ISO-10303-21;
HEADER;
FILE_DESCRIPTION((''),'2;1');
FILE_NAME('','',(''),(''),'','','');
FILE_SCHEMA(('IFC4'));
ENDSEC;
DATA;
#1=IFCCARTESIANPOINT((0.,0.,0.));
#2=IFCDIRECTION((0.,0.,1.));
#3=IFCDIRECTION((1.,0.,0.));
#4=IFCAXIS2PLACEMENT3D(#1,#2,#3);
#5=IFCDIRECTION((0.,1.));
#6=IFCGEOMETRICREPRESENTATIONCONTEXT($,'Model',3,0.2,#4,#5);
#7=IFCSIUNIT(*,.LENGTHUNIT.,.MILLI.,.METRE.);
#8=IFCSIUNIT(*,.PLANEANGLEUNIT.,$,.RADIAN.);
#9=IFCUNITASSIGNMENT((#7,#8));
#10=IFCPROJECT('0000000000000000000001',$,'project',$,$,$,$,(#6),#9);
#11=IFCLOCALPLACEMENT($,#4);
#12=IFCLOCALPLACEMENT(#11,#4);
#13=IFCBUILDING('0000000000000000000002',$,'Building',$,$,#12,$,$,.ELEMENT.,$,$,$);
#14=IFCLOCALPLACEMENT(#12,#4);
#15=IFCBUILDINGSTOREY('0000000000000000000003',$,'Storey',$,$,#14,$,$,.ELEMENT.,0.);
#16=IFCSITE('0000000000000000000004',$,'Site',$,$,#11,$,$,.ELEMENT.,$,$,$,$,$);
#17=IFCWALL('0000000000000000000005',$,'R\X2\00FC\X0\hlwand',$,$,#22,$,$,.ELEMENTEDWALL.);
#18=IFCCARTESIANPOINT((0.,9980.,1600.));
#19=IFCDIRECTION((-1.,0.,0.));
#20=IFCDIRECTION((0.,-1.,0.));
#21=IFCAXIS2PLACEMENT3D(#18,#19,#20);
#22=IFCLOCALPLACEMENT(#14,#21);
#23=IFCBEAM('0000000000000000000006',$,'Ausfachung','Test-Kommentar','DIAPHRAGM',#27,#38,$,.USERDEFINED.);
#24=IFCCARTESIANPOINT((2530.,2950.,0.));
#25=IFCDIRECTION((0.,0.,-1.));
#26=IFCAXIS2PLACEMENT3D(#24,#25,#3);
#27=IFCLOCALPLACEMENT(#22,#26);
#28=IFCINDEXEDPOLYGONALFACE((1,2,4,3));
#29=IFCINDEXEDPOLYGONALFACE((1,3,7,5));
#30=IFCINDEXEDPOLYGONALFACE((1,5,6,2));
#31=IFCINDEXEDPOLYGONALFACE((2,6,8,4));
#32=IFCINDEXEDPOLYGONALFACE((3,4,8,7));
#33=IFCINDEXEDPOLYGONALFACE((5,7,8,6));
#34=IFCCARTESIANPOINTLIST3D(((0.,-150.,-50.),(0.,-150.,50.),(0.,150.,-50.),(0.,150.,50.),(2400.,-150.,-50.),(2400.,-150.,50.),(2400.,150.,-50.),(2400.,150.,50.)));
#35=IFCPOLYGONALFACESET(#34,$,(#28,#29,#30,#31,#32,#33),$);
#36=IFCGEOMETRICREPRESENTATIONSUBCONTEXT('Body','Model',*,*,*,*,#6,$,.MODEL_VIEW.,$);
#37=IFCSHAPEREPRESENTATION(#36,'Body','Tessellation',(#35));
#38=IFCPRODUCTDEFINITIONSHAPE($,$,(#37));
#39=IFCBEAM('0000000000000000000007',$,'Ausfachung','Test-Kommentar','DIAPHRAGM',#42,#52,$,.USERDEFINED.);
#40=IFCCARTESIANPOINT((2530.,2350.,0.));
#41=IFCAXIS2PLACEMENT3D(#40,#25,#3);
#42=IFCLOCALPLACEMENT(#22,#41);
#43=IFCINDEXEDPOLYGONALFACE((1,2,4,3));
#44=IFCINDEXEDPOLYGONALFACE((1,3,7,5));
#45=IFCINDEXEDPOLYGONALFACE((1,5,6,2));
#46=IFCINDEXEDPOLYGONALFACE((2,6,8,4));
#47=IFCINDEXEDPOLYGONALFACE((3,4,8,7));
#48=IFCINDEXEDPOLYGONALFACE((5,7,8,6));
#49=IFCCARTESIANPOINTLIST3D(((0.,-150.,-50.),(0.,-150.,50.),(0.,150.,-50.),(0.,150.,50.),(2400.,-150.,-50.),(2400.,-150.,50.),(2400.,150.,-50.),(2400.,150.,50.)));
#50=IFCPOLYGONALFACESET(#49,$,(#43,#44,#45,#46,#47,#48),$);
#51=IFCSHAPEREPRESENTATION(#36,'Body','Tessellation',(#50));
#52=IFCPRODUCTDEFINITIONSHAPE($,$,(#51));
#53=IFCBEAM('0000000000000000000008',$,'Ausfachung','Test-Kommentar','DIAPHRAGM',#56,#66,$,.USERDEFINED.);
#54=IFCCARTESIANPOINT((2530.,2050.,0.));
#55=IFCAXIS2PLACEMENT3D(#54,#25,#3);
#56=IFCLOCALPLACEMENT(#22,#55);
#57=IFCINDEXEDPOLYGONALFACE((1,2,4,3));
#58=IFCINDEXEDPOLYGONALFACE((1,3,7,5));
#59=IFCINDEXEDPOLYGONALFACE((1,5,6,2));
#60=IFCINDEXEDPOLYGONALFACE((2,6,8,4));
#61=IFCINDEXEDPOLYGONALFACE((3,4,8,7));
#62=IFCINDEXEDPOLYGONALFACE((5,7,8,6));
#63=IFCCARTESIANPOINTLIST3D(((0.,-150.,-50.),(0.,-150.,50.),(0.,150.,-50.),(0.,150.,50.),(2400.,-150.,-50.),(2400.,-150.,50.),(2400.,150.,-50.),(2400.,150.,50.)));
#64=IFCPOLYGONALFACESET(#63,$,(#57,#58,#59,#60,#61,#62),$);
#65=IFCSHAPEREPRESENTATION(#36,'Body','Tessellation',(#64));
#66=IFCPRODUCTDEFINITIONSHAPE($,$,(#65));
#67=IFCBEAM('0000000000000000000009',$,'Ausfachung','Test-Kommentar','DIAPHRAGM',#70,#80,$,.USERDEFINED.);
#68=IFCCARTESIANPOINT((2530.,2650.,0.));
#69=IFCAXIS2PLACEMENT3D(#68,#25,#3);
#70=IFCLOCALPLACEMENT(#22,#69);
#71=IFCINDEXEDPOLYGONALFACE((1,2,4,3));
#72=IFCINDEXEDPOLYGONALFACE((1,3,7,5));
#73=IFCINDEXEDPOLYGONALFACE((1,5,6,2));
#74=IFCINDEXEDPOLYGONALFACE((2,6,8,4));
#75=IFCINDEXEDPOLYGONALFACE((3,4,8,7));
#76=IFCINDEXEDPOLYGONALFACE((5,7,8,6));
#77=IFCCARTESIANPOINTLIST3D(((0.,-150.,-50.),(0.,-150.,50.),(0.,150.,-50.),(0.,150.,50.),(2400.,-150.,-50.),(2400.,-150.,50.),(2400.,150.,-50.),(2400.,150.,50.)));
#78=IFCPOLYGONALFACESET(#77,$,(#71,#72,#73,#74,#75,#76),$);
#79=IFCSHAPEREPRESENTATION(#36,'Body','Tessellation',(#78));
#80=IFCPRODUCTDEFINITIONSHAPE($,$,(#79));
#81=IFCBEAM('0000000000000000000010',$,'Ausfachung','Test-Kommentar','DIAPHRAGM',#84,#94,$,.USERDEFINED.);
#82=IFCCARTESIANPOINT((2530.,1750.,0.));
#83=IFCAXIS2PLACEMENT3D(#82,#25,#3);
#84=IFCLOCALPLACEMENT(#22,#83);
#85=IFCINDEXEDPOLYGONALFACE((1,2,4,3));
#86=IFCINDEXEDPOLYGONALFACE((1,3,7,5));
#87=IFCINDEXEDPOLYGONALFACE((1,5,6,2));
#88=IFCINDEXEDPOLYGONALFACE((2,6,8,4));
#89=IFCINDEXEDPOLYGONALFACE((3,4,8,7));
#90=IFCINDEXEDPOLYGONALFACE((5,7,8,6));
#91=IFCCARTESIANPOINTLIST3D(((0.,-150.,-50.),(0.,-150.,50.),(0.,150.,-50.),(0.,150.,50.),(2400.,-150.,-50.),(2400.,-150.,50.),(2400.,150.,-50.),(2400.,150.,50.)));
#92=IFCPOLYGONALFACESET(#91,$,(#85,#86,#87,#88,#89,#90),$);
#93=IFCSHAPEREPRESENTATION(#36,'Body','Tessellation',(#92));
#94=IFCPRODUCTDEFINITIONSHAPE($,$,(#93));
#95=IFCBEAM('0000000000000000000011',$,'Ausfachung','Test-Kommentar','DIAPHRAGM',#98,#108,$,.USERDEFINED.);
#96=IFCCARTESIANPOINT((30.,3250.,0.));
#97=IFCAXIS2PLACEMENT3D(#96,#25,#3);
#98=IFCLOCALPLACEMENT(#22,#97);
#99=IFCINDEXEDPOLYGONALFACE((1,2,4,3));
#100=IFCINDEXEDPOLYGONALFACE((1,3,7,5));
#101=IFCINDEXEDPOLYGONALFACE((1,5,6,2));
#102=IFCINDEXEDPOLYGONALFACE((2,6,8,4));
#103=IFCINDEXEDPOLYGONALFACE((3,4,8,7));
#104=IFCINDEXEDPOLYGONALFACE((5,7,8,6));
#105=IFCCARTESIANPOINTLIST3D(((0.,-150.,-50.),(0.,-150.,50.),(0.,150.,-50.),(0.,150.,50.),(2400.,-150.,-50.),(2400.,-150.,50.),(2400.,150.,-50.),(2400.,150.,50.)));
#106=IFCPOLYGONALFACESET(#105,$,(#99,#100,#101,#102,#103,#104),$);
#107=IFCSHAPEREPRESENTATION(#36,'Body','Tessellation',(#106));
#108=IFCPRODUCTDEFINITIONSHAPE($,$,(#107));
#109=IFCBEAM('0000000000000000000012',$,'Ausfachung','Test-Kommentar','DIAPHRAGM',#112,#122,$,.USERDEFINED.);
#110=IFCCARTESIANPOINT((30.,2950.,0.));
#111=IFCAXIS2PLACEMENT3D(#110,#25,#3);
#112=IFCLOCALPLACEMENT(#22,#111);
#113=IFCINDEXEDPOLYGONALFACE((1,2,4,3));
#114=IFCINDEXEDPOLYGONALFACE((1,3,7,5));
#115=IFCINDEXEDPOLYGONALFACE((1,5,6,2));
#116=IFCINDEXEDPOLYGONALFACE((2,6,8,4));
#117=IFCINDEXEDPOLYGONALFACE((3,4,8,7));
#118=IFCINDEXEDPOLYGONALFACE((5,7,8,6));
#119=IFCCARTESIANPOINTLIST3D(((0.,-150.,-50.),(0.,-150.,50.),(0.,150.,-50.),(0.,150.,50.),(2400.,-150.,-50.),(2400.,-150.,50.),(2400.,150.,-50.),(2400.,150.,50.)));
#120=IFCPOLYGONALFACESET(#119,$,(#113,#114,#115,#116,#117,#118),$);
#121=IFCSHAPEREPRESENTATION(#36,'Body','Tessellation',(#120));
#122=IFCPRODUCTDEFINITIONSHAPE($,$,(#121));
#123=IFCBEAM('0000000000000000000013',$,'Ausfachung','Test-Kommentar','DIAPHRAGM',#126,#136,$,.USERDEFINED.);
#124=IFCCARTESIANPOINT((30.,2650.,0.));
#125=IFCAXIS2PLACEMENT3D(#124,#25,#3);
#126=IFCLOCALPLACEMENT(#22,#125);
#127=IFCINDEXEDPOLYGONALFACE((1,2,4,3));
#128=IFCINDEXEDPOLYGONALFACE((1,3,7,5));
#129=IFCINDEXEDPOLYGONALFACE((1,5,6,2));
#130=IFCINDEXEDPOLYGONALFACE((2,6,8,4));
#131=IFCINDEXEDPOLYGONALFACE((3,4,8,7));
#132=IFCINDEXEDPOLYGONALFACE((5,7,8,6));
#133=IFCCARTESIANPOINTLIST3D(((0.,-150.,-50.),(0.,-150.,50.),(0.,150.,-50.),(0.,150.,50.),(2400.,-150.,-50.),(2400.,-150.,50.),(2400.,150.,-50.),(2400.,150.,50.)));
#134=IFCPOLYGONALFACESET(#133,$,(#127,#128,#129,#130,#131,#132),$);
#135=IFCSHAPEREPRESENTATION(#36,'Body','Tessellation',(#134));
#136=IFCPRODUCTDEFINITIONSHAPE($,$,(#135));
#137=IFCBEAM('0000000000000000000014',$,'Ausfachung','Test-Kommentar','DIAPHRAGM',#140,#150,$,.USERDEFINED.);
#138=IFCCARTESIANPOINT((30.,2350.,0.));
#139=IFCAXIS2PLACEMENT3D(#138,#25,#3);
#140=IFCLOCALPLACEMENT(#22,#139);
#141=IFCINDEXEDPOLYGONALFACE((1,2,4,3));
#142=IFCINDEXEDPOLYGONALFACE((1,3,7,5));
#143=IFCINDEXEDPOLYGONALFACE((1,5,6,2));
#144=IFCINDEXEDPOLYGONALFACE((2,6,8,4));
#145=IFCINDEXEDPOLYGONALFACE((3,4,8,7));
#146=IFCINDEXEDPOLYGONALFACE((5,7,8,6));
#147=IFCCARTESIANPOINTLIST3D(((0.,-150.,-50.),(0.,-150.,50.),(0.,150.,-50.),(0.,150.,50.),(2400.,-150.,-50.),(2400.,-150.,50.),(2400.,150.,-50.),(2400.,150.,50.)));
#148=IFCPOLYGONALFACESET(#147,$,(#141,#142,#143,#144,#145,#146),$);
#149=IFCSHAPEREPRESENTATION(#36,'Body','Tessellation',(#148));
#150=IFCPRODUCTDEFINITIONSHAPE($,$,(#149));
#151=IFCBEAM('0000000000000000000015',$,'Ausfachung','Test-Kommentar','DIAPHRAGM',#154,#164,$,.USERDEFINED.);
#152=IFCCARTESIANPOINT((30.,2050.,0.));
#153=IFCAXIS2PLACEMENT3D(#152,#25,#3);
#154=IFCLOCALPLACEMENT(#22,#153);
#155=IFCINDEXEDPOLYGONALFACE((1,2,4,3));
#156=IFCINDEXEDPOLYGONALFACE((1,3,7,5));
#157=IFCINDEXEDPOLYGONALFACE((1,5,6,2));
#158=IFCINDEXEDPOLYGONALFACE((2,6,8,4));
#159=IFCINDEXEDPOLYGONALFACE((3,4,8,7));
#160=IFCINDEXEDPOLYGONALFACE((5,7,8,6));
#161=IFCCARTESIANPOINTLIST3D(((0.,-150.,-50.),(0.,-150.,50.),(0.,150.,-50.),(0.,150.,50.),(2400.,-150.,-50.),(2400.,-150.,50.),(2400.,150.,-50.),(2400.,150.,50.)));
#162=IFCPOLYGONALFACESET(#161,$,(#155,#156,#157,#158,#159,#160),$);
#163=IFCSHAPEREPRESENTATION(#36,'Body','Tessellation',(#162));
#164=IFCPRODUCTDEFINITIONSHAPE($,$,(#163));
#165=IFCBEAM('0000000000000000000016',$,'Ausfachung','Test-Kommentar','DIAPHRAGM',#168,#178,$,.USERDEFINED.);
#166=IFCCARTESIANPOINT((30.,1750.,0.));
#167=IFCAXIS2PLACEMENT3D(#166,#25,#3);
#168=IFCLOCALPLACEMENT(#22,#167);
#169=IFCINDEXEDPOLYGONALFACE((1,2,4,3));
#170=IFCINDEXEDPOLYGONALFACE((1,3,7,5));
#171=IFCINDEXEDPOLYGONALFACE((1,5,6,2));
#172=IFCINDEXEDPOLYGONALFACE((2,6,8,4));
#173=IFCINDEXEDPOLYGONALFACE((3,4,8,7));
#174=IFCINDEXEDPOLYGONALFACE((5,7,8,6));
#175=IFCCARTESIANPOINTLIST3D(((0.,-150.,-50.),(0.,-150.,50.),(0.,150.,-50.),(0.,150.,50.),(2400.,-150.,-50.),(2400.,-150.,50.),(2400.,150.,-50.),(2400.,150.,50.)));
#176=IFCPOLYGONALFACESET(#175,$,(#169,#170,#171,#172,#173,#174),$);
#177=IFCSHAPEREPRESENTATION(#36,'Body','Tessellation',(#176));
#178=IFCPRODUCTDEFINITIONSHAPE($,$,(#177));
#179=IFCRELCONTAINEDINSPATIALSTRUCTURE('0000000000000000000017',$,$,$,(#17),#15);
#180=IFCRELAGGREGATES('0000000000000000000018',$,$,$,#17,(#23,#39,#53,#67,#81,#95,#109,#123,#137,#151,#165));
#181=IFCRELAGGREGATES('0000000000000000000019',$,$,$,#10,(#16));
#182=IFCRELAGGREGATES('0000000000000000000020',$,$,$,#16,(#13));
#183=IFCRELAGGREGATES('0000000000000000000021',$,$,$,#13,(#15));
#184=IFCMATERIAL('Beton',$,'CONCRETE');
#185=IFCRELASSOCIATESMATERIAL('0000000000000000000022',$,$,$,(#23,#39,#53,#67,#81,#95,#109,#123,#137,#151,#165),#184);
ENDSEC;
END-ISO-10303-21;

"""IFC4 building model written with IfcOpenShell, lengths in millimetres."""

from ifc_helpers import new_model, si_unit, direction, frame, origin_with_axes, place, context, subcontext, project, spatial, line, indexed_curve, outline, extrude, material, element, aggregate, save


model = new_model("IFC4")

# Units and contexts
model_context = context("Model", 3, precision=0.2, world=origin_with_axes(), true_north=direction((0.0, 1.0)))
body_context = subcontext(model_context, "Body", "Model", "MODEL_VIEW")
ifc_project = project(units=[si_unit("LENGTHUNIT", "METRE", prefix="MILLI"), si_unit("PLANEANGLEUNIT", "RADIAN")], contexts=[model_context])

# Site, building, storey
site_placement = place(None, origin_with_axes())
site = spatial("IfcSite", under=ifc_project, at=site_placement, Name="Site", CompositionType="ELEMENT")
building_placement = place(site_placement, origin_with_axes())
building = spatial("IfcBuilding", under=site, at=building_placement, Name="Building", CompositionType="ELEMENT")
storey_placement = place(building_placement, origin_with_axes())
storey = spatial("IfcBuildingStorey", under=building, at=storey_placement, Name="Storey", CompositionType="ELEMENT", Elevation=0.0)

# Wall, beams
wall_placement = place(storey_placement, frame((0.0, 9980.0, 1600.0), z_axis=(-1.0, 0.0, 0.0), x_axis=(0.0, -1.0, 0.0)))
wall = element("IfcWall", 1, at=wall_placement, inside=storey, Name="Rühlwand", PredefinedType="ELEMENTEDWALL")
ifc_material_1 = material(Name="Beton", Category="CONCRETE")
beam_1_placement = place(wall_placement, frame((2530.0, 2950.0, 0.0), z_axis=(0.0, 0.0, -1.0), x_axis=(1.0, 0.0, 0.0)))
beam_1 = element("IfcBeam", 2, at=beam_1_placement, material=ifc_material_1, Name="Ausfachung", Description="Test-Kommentar", ObjectType="DIAPHRAGM", PredefinedType="USERDEFINED", context=body_context, shape_type="SolidModel", body=[
    extrude(outline(indexed_curve([(-50.0, -150.0), (50.0, -150.0), (50.0, 150.0), (-50.0, 150.0)], segments=[line(1, 2, 3, 4, 1)])), frame((0.0, 0.0, 0.0), z_axis=(-1.0, 0.0, 0.0), x_axis=(0.0, 0.0, 1.0)), (0.0, 0.0, -1.0), 2400.0),
])
beam_2_placement = place(wall_placement, frame((2530.0, 2350.0, 0.0), z_axis=(0.0, 0.0, -1.0), x_axis=(1.0, 0.0, 0.0)))
beam_2 = element("IfcBeam", 3, at=beam_2_placement, material=ifc_material_1, Name="Ausfachung", Description="Test-Kommentar", ObjectType="DIAPHRAGM", PredefinedType="USERDEFINED", context=body_context, shape_type="SolidModel", body=[
    extrude(outline(indexed_curve([(-50.0, -150.0), (50.0, -150.0), (50.0, 150.0), (-50.0, 150.0)], segments=[line(1, 2, 3, 4, 1)])), frame((0.0, 0.0, 0.0), z_axis=(-1.0, 0.0, 0.0), x_axis=(0.0, 0.0, 1.0)), (0.0, 0.0, -1.0), 2400.0),
])
beam_3_placement = place(wall_placement, frame((2530.0, 2050.0, 0.0), z_axis=(0.0, 0.0, -1.0), x_axis=(1.0, 0.0, 0.0)))
beam_3 = element("IfcBeam", 4, at=beam_3_placement, material=ifc_material_1, Name="Ausfachung", Description="Test-Kommentar", ObjectType="DIAPHRAGM", PredefinedType="USERDEFINED", context=body_context, shape_type="SolidModel", body=[
    extrude(outline(indexed_curve([(-50.0, -150.0), (50.0, -150.0), (50.0, 150.0), (-50.0, 150.0)], segments=[line(1, 2, 3, 4, 1)])), frame((0.0, 0.0, 0.0), z_axis=(-1.0, 0.0, 0.0), x_axis=(0.0, 0.0, 1.0)), (0.0, 0.0, -1.0), 2400.0),
])
beam_4_placement = place(wall_placement, frame((2530.0, 2650.0, 0.0), z_axis=(0.0, 0.0, -1.0), x_axis=(1.0, 0.0, 0.0)))
beam_4 = element("IfcBeam", 5, at=beam_4_placement, material=ifc_material_1, Name="Ausfachung", Description="Test-Kommentar", ObjectType="DIAPHRAGM", PredefinedType="USERDEFINED", context=body_context, shape_type="SolidModel", body=[
    extrude(outline(indexed_curve([(-50.0, -150.0), (50.0, -150.0), (50.0, 150.0), (-50.0, 150.0)], segments=[line(1, 2, 3, 4, 1)])), frame((0.0, 0.0, 0.0), z_axis=(-1.0, 0.0, 0.0), x_axis=(0.0, 0.0, 1.0)), (0.0, 0.0, -1.0), 2400.0),
])
beam_5_placement = place(wall_placement, frame((2530.0, 1750.0, 0.0), z_axis=(0.0, 0.0, -1.0), x_axis=(1.0, 0.0, 0.0)))
beam_5 = element("IfcBeam", 6, at=beam_5_placement, material=ifc_material_1, Name="Ausfachung", Description="Test-Kommentar", ObjectType="DIAPHRAGM", PredefinedType="USERDEFINED", context=body_context, shape_type="SolidModel", body=[
    extrude(outline(indexed_curve([(-50.0, -150.0), (50.0, -150.0), (50.0, 150.0), (-50.0, 150.0)], segments=[line(1, 2, 3, 4, 1)])), frame((0.0, 0.0, 0.0), z_axis=(-1.0, 0.0, 0.0), x_axis=(0.0, 0.0, 1.0)), (0.0, 0.0, -1.0), 2400.0),
])
beam_6_placement = place(wall_placement, frame((30.0, 3250.0, 0.0), z_axis=(0.0, 0.0, -1.0), x_axis=(1.0, 0.0, 0.0)))
beam_6 = element("IfcBeam", 7, at=beam_6_placement, material=ifc_material_1, Name="Ausfachung", Description="Test-Kommentar", ObjectType="DIAPHRAGM", PredefinedType="USERDEFINED", context=body_context, shape_type="SolidModel", body=[
    extrude(outline(indexed_curve([(-50.0, -150.0), (50.0, -150.0), (50.0, 150.0), (-50.0, 150.0)], segments=[line(1, 2, 3, 4, 1)])), frame((0.0, 0.0, 0.0), z_axis=(-1.0, 0.0, 0.0), x_axis=(0.0, 0.0, 1.0)), (0.0, 0.0, -1.0), 2400.0),
])
beam_7_placement = place(wall_placement, frame((30.0, 2950.0, 0.0), z_axis=(0.0, 0.0, -1.0), x_axis=(1.0, 0.0, 0.0)))
beam_7 = element("IfcBeam", 8, at=beam_7_placement, material=ifc_material_1, Name="Ausfachung", Description="Test-Kommentar", ObjectType="DIAPHRAGM", PredefinedType="USERDEFINED", context=body_context, shape_type="SolidModel", body=[
    extrude(outline(indexed_curve([(-50.0, -150.0), (50.0, -150.0), (50.0, 150.0), (-50.0, 150.0)], segments=[line(1, 2, 3, 4, 1)])), frame((0.0, 0.0, 0.0), z_axis=(-1.0, 0.0, 0.0), x_axis=(0.0, 0.0, 1.0)), (0.0, 0.0, -1.0), 2400.0),
])
beam_8_placement = place(wall_placement, frame((30.0, 2650.0, 0.0), z_axis=(0.0, 0.0, -1.0), x_axis=(1.0, 0.0, 0.0)))
beam_8 = element("IfcBeam", 9, at=beam_8_placement, material=ifc_material_1, Name="Ausfachung", Description="Test-Kommentar", ObjectType="DIAPHRAGM", PredefinedType="USERDEFINED", context=body_context, shape_type="SolidModel", body=[
    extrude(outline(indexed_curve([(-50.0, -150.0), (50.0, -150.0), (50.0, 150.0), (-50.0, 150.0)], segments=[line(1, 2, 3, 4, 1)])), frame((0.0, 0.0, 0.0), z_axis=(-1.0, 0.0, 0.0), x_axis=(0.0, 0.0, 1.0)), (0.0, 0.0, -1.0), 2400.0),
])
beam_9_placement = place(wall_placement, frame((30.0, 2350.0, 0.0), z_axis=(0.0, 0.0, -1.0), x_axis=(1.0, 0.0, 0.0)))
beam_9 = element("IfcBeam", 10, at=beam_9_placement, material=ifc_material_1, Name="Ausfachung", Description="Test-Kommentar", ObjectType="DIAPHRAGM", PredefinedType="USERDEFINED", context=body_context, shape_type="SolidModel", body=[
    extrude(outline(indexed_curve([(-50.0, -150.0), (50.0, -150.0), (50.0, 150.0), (-50.0, 150.0)], segments=[line(1, 2, 3, 4, 1)])), frame((0.0, 0.0, 0.0), z_axis=(-1.0, 0.0, 0.0), x_axis=(0.0, 0.0, 1.0)), (0.0, 0.0, -1.0), 2400.0),
])
beam_10_placement = place(wall_placement, frame((30.0, 2050.0, 0.0), z_axis=(0.0, 0.0, -1.0), x_axis=(1.0, 0.0, 0.0)))
beam_10 = element("IfcBeam", 11, at=beam_10_placement, material=ifc_material_1, Name="Ausfachung", Description="Test-Kommentar", ObjectType="DIAPHRAGM", PredefinedType="USERDEFINED", context=body_context, shape_type="SolidModel", body=[
    extrude(outline(indexed_curve([(-50.0, -150.0), (50.0, -150.0), (50.0, 150.0), (-50.0, 150.0)], segments=[line(1, 2, 3, 4, 1)])), frame((0.0, 0.0, 0.0), z_axis=(-1.0, 0.0, 0.0), x_axis=(0.0, 0.0, 1.0)), (0.0, 0.0, -1.0), 2400.0),
])
beam_11_placement = place(wall_placement, frame((30.0, 1750.0, 0.0), z_axis=(0.0, 0.0, -1.0), x_axis=(1.0, 0.0, 0.0)))
beam_11 = element("IfcBeam", 12, at=beam_11_placement, material=ifc_material_1, Name="Ausfachung", Description="Test-Kommentar", ObjectType="DIAPHRAGM", PredefinedType="USERDEFINED", context=body_context, shape_type="SolidModel", body=[
    extrude(outline(indexed_curve([(-50.0, -150.0), (50.0, -150.0), (50.0, 150.0), (-50.0, 150.0)], segments=[line(1, 2, 3, 4, 1)])), frame((0.0, 0.0, 0.0), z_axis=(-1.0, 0.0, 0.0), x_axis=(0.0, 0.0, 1.0)), (0.0, 0.0, -1.0), 2400.0),
])
aggregate(wall, [beam_1, beam_2, beam_3, beam_4, beam_5, beam_6, beam_7, beam_8, beam_9, beam_10, beam_11])

save(model, "model.ifc")
